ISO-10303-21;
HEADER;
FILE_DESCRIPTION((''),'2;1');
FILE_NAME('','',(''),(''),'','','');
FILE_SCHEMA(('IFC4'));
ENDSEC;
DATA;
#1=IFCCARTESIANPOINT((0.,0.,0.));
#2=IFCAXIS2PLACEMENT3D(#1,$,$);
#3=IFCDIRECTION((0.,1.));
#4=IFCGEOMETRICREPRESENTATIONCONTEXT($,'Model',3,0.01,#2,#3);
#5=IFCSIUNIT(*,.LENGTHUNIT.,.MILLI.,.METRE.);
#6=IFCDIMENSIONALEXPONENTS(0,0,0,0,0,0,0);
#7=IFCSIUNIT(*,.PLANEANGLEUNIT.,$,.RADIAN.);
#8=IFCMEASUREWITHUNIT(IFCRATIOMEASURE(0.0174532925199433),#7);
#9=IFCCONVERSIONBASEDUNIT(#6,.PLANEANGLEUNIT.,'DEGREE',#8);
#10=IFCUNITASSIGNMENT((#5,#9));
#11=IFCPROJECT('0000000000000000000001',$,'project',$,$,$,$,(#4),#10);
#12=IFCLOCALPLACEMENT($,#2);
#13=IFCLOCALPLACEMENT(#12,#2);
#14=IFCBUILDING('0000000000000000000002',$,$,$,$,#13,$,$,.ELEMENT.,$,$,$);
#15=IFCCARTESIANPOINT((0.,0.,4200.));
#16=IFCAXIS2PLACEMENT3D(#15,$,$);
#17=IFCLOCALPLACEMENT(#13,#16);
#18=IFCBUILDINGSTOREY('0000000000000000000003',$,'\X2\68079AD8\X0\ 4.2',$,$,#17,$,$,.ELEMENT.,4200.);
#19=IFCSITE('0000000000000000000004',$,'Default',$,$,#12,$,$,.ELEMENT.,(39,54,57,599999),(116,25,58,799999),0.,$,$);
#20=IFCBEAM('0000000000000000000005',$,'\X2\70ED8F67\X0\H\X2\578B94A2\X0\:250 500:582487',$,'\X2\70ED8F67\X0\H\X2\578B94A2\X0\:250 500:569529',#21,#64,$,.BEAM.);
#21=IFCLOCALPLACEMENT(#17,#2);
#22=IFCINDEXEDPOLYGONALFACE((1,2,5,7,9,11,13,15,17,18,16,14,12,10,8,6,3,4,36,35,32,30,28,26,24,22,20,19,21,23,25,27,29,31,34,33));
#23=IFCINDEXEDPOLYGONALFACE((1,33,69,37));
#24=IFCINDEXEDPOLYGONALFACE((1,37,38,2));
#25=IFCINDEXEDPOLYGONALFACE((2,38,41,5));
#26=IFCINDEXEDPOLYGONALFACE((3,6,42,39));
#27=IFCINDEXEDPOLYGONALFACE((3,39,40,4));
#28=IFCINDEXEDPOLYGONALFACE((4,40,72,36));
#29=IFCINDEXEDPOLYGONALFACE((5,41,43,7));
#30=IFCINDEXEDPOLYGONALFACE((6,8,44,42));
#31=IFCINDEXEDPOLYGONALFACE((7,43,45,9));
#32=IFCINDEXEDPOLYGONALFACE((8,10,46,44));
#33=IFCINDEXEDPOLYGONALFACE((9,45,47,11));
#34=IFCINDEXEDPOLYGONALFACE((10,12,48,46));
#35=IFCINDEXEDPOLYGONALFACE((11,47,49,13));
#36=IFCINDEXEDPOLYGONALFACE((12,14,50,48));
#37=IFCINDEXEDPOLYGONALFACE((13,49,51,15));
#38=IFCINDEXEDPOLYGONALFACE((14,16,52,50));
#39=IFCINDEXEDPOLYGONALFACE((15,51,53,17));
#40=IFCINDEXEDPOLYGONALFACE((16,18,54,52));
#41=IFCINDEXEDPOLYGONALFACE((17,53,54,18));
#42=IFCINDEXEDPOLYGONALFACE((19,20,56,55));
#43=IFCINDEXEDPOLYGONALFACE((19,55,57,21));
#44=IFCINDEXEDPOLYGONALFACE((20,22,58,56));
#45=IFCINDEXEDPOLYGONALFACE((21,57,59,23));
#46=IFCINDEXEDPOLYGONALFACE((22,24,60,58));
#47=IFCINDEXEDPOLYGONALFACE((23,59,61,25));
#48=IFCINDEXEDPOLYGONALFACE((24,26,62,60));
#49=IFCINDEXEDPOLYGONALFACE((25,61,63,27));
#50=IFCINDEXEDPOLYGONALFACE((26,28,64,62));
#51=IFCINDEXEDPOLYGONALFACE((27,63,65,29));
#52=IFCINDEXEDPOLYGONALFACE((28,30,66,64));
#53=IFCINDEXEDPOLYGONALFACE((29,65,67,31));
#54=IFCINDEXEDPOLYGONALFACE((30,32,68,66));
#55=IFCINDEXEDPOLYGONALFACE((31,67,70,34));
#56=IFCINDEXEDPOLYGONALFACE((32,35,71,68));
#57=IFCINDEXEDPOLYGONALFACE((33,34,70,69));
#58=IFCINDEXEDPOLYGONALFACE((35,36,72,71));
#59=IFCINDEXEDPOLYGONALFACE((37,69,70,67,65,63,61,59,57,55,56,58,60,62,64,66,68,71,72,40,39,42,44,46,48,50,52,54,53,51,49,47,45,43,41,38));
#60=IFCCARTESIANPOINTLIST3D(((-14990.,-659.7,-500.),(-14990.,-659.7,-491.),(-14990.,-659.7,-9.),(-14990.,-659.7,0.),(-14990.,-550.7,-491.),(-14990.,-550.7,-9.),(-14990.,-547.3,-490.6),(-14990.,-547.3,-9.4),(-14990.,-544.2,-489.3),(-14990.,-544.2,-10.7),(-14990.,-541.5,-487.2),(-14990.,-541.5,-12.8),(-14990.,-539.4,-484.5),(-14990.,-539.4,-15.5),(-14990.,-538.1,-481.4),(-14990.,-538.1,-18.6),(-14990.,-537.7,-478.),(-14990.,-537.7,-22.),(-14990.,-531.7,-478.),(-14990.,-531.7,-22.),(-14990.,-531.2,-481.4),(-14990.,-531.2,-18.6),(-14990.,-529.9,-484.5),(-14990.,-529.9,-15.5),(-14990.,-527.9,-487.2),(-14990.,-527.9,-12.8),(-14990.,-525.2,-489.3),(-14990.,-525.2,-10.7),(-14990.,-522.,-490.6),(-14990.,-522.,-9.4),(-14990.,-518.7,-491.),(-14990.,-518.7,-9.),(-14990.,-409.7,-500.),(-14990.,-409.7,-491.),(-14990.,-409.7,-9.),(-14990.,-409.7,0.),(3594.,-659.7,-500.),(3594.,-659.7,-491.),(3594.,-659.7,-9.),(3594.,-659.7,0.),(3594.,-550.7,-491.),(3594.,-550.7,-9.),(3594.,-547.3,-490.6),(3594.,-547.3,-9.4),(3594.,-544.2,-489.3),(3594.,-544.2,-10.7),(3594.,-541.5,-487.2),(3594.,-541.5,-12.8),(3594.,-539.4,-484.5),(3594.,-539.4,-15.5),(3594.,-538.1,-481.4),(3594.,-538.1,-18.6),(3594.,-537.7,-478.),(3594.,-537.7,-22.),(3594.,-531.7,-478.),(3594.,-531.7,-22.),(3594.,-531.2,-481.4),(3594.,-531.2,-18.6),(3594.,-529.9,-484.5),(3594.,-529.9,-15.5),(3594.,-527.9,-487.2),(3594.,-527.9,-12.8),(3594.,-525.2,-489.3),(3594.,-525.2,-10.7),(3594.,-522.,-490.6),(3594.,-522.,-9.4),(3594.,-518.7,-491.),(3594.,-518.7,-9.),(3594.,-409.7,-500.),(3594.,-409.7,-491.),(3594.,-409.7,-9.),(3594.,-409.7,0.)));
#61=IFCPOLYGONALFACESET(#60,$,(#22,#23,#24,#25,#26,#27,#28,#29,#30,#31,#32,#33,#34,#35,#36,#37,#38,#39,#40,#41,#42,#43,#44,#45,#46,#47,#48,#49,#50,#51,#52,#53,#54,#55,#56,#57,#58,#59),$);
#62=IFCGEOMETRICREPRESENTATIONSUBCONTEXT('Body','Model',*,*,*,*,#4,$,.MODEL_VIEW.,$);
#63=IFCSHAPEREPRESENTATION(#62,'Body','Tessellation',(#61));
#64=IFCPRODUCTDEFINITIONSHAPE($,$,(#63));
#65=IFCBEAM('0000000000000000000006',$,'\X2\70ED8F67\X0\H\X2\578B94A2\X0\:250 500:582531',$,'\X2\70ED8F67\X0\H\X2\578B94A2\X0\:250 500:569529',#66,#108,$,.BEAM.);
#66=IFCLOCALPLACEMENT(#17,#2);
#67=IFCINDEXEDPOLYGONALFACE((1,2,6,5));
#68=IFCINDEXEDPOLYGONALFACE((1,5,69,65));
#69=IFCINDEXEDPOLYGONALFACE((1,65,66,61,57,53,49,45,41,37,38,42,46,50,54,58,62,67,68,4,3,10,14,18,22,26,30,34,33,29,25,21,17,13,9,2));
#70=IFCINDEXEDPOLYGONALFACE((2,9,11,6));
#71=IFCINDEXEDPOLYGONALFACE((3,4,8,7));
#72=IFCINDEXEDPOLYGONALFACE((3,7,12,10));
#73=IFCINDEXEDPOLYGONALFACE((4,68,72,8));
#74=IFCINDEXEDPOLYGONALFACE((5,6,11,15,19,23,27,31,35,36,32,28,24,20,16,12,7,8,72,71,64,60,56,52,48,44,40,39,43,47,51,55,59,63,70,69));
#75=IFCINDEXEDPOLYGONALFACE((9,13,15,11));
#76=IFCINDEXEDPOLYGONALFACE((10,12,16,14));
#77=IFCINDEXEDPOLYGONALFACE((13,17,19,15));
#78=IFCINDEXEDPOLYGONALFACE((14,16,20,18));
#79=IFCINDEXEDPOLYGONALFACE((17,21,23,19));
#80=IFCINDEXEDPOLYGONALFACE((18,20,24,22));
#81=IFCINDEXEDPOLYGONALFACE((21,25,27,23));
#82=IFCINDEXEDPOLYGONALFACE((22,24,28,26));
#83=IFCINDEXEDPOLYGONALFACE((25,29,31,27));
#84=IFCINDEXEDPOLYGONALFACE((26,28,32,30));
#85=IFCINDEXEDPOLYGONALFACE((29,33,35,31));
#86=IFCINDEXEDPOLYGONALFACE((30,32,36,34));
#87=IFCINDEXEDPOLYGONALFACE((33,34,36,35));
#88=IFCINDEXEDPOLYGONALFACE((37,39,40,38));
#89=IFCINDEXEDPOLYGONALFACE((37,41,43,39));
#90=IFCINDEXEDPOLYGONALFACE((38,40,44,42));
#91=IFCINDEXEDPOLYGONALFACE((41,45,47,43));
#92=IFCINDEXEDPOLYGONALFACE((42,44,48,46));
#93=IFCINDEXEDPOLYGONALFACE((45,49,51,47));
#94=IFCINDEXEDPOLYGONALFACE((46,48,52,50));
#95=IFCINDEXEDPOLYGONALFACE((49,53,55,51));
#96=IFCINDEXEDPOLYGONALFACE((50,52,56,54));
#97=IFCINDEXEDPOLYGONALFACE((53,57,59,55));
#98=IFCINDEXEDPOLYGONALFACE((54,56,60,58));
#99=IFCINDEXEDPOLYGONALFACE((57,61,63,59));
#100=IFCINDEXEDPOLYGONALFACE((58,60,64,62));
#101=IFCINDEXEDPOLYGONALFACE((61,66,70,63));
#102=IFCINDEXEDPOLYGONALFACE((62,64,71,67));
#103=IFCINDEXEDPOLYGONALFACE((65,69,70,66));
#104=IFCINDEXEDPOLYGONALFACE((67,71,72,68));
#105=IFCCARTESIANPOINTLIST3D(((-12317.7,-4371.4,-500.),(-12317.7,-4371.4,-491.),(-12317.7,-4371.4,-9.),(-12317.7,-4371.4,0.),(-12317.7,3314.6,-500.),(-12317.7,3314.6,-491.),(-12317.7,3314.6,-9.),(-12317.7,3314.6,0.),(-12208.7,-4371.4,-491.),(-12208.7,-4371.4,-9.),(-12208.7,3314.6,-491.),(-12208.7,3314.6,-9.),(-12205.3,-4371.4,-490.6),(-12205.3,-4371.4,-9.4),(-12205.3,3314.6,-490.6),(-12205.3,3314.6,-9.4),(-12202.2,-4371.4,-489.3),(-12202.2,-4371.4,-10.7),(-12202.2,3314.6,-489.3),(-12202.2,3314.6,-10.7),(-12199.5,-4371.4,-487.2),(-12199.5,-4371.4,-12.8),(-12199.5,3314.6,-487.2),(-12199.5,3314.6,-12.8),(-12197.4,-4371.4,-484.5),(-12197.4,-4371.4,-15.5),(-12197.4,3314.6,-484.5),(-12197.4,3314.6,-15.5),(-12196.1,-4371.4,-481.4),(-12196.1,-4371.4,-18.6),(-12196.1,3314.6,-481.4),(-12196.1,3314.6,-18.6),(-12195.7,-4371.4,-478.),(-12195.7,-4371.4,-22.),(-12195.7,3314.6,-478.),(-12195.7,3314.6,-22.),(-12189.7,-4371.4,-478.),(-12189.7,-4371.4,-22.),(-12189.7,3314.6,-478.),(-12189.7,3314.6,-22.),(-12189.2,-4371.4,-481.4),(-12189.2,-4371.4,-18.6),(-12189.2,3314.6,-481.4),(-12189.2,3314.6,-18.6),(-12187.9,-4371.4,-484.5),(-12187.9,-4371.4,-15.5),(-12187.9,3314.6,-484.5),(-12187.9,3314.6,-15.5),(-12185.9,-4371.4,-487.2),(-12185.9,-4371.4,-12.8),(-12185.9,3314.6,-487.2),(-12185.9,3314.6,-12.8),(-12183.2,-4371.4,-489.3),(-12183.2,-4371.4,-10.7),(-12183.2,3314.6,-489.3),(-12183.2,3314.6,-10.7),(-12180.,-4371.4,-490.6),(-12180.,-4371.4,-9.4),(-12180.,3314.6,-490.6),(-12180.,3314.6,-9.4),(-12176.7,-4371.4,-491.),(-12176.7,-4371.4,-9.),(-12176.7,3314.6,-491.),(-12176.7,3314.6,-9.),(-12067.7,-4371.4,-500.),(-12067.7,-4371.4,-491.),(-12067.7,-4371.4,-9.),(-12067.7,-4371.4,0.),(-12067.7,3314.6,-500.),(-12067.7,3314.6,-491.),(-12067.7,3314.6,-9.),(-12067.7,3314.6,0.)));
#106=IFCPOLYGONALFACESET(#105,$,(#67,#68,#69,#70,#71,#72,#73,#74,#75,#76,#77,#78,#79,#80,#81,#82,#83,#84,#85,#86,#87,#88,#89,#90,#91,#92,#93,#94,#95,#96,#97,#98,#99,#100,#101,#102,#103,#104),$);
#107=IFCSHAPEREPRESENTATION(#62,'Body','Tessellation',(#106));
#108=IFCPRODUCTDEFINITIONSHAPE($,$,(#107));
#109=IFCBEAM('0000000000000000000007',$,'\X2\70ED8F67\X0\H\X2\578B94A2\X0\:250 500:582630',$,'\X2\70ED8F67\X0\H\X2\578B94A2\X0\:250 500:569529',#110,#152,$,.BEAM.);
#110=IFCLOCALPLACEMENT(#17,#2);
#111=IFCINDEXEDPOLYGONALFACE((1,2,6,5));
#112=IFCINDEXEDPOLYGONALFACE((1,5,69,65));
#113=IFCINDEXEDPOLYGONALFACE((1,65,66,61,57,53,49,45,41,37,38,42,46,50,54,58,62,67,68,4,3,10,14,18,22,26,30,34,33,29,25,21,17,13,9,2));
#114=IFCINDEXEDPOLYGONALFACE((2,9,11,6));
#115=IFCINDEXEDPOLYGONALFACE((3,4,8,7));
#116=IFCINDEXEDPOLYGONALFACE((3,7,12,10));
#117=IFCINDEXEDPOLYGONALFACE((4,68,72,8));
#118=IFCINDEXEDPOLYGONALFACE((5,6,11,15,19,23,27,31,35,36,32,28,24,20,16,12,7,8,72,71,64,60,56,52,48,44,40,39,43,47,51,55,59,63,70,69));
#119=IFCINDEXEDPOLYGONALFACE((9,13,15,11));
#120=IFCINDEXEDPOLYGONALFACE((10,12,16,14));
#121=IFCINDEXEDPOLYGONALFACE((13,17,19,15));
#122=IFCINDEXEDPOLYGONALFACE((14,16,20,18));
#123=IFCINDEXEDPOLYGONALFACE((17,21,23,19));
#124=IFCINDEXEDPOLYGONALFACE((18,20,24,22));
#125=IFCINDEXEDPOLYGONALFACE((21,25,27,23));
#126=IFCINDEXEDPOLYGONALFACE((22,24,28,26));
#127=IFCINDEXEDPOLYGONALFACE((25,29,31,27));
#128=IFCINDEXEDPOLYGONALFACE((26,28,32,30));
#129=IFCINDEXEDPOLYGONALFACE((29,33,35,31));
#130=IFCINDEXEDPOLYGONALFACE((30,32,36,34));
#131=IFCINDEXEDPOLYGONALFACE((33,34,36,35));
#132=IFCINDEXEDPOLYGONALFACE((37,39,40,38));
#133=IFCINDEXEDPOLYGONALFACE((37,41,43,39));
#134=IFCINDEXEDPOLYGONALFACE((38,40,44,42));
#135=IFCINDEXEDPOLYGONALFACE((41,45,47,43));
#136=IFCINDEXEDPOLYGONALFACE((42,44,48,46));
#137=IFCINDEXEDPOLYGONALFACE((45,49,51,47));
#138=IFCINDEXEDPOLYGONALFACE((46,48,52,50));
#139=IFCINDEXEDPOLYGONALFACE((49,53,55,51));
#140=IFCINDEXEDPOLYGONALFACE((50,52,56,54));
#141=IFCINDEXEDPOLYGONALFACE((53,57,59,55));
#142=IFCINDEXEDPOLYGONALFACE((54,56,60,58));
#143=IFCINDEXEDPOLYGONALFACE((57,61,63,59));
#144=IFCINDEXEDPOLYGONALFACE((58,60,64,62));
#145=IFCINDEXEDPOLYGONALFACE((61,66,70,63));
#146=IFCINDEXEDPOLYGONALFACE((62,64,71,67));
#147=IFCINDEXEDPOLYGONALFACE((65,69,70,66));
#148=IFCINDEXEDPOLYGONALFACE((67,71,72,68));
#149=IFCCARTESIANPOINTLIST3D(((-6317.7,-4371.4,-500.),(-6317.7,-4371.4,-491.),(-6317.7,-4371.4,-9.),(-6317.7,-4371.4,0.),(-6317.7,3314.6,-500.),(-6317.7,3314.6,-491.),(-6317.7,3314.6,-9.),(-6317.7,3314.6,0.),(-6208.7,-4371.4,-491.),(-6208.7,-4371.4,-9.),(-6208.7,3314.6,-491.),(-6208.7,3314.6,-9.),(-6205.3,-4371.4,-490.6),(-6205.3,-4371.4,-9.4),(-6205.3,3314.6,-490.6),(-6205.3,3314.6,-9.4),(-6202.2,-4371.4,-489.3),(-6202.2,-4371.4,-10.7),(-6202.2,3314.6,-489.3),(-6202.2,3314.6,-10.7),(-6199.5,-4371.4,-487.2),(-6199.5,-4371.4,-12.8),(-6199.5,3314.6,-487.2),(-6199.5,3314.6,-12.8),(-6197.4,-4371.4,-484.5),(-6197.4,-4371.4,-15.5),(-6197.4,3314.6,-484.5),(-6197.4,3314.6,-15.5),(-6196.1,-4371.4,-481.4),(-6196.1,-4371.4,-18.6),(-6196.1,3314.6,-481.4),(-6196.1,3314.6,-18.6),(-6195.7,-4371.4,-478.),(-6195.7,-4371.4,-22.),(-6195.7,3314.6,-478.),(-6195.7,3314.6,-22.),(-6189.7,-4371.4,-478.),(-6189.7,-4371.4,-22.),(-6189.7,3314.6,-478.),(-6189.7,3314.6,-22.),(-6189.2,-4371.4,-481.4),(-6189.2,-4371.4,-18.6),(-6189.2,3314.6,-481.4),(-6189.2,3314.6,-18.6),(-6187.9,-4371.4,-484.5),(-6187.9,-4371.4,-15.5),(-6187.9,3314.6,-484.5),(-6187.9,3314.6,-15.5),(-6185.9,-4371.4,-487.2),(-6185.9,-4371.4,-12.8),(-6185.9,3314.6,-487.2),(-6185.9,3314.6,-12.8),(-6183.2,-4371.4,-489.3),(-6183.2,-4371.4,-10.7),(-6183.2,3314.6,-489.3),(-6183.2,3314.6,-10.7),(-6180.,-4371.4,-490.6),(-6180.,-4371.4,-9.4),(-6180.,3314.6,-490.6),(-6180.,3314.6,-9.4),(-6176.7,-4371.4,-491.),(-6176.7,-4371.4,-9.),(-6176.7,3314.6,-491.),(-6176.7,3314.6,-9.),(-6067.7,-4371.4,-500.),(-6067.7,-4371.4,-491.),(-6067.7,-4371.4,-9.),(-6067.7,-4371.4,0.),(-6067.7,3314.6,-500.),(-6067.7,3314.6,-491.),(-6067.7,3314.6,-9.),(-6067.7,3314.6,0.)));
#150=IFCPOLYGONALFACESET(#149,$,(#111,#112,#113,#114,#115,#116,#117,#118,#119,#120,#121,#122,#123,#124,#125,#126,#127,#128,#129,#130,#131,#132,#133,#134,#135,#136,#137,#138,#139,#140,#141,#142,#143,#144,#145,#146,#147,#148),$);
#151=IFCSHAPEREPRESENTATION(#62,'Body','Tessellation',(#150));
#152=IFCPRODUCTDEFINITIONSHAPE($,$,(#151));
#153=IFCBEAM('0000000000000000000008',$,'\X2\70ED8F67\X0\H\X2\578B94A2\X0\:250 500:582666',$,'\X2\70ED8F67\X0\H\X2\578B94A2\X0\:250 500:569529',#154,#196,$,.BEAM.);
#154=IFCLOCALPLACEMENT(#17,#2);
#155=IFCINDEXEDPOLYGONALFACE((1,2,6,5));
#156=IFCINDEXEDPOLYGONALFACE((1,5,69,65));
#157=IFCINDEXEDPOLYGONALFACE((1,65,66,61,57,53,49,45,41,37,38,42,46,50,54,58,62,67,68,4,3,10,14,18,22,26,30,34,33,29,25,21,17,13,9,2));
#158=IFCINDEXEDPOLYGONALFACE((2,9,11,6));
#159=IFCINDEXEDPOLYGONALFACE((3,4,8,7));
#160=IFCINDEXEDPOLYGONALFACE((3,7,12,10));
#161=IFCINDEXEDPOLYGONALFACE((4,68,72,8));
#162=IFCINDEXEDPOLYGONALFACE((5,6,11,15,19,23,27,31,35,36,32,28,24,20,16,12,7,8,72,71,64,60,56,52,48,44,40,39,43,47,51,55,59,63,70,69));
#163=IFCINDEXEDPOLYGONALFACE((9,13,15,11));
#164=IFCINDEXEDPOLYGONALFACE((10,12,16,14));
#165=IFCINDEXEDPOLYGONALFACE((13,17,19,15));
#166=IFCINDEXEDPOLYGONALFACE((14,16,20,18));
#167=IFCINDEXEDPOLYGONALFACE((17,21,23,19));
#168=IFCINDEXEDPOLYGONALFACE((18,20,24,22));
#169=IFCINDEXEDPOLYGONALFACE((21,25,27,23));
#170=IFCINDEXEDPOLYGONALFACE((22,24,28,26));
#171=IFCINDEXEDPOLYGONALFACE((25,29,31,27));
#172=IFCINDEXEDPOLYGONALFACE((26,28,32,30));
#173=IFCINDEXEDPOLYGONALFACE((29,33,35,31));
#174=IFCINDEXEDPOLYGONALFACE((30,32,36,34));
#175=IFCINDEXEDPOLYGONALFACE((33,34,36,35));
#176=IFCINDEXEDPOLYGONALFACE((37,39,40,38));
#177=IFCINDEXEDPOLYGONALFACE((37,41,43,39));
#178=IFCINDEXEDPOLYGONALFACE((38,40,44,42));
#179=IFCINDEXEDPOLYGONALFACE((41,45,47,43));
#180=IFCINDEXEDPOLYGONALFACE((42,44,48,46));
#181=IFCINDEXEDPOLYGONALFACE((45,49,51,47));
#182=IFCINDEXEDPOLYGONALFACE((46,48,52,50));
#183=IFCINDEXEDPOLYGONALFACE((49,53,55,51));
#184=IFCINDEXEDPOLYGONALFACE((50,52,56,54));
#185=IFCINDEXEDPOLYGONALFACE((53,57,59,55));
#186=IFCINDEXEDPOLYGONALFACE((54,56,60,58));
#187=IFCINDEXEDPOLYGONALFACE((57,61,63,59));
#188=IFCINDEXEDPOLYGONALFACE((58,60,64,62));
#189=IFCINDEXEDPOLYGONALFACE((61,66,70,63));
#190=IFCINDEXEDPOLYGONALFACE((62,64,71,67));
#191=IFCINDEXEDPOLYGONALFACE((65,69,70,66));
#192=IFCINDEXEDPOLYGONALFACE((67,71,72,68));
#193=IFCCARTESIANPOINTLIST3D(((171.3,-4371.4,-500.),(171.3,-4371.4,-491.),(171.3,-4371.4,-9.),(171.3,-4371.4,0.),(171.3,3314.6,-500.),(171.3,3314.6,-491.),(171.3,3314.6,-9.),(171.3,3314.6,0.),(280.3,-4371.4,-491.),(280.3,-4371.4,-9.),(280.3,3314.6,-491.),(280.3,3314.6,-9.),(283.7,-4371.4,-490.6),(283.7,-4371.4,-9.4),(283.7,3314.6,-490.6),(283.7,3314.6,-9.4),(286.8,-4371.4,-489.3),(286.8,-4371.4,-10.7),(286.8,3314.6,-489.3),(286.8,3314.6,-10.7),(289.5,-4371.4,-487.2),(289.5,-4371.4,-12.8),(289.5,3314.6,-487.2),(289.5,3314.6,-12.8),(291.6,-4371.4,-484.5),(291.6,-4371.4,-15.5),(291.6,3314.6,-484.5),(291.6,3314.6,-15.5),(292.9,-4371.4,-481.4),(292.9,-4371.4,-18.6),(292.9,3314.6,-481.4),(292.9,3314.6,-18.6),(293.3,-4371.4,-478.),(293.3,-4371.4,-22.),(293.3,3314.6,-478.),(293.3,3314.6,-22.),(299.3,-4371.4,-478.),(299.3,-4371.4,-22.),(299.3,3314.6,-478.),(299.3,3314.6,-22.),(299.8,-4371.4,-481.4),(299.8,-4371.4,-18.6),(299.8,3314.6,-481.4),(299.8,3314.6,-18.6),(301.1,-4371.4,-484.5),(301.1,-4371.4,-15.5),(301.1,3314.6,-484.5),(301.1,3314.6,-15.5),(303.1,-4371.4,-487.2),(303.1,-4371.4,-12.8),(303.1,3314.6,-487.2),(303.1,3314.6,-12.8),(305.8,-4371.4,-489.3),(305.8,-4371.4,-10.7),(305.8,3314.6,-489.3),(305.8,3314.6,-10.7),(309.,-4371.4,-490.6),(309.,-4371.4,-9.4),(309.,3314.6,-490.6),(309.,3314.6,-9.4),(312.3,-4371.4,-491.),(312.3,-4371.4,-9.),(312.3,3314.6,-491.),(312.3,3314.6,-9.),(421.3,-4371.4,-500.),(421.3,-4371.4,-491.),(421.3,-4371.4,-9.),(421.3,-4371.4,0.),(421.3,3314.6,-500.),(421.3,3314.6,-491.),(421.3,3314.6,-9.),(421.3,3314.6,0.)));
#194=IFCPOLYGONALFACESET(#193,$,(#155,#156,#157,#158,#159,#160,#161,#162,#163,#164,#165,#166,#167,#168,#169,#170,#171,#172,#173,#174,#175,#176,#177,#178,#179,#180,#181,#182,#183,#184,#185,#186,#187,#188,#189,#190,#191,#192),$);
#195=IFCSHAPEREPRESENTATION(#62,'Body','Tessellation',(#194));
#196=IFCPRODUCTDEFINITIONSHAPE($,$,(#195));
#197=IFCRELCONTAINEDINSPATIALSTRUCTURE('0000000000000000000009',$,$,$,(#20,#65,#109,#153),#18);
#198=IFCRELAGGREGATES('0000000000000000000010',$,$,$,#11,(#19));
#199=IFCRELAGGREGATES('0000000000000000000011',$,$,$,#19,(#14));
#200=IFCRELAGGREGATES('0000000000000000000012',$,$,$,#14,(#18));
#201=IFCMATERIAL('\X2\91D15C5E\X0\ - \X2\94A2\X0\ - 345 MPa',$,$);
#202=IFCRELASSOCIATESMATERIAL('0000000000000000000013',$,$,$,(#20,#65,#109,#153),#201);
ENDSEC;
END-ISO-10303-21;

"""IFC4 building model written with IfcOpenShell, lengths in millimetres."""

from ifc_helpers import new_model, entity, si_unit, converted_unit, direction, frame, frame_2d, origin, place, context, subcontext, project, spatial, i_section, extrude, material, element, save


model = new_model("IFC4")

# Units and contexts
model_context = context("Model", 3, precision=0.01, world=origin(), true_north=direction((0.0, 1.0)))
body_context = subcontext(model_context, "Body", "Model", "MODEL_VIEW")
ifc_project = project(units=[si_unit("LENGTHUNIT", "METRE", prefix="MILLI"), converted_unit("PLANEANGLEUNIT", "DEGREE", entity("IfcRatioMeasure", 0.0174532925199433), si_unit("PLANEANGLEUNIT", "RADIAN"), dimensions=[0, 0, 0, 0, 0, 0, 0])], contexts=[model_context])

# Site, building, storey
site_placement = place(None, origin())
site = spatial("IfcSite", under=ifc_project, at=site_placement, Name="Default", CompositionType="ELEMENT", RefLatitude=(39, 54, 57, 599999), RefLongitude=(116, 25, 58, 799999), RefElevation=0.0)
building_placement = place(site_placement, origin())
building = spatial("IfcBuilding", under=site, at=building_placement, CompositionType="ELEMENT")
storey_placement = place(building_placement, frame((0.0, 0.0, 4200.0)))
storey = spatial("IfcBuildingStorey", under=building, at=storey_placement, Name="标高 4.2", CompositionType="ELEMENT", Elevation=4200.0)

# Beams
ifc_material_1 = material(Name="金属 - 钢 - 345 MPa")
beam_1_placement = place(storey_placement, frame((-14990.3, -534.7, 0.0)))
element("IfcBeam", 1, at=beam_1_placement, inside=storey, material=ifc_material_1, Name="热轧H型钢:250 500:582487", ObjectType="热轧H型钢:250 500:569529", PredefinedType="BEAM", context=body_context, shape_type="SweptSolid", body=[
    extrude(i_section(OverallWidth=250.0, OverallDepth=500.0, WebThickness=6.0, FlangeThickness=9.0, FilletRadius=13.0, at=frame_2d((0.0, 0.0), x_axis=(0.0, 1.0))), frame((0.3, 0.0, -250.0), z_axis=(1.0, 0.0, 0.0), x_axis=(0.0, 0.0, -1.0)), (0.0, 0.0, 1.0), 18584.0),
])
beam_2_placement = place(storey_placement, frame((-12192.7, -4534.7, 0.0), z_axis=(0.0, 0.0, 1.0), x_axis=(0.0, 1.0, 0.0)))
element("IfcBeam", 2, at=beam_2_placement, inside=storey, material=ifc_material_1, Name="热轧H型钢:250 500:582531", ObjectType="热轧H型钢:250 500:569529", PredefinedType="BEAM", context=body_context, shape_type="SweptSolid", body=[
    extrude(i_section(OverallWidth=250.0, OverallDepth=500.0, WebThickness=6.0, FlangeThickness=9.0, FilletRadius=13.0, at=frame_2d((0.0, 0.0), x_axis=(0.0, 1.0))), frame((163.3, 0.0, -250.0), z_axis=(1.0, 0.0, 0.0), x_axis=(0.0, 0.0, -1.0)), (0.0, 0.0, 1.0), 7686.0),
])
beam_3_placement = place(storey_placement, frame((-6192.7, 3314.9, 0.0), z_axis=(0.0, 0.0, 1.0), x_axis=(0.0, -1.0, 0.0)))
element("IfcBeam", 3, at=beam_3_placement, inside=storey, material=ifc_material_1, Name="热轧H型钢:250 500:582630", ObjectType="热轧H型钢:250 500:569529", PredefinedType="BEAM", context=body_context, shape_type="SweptSolid", body=[
    extrude(i_section(OverallWidth=250.0, OverallDepth=500.0, WebThickness=6.0, FlangeThickness=9.0, FilletRadius=13.0, at=frame_2d((0.0, 0.0), x_axis=(0.0, 1.0))), frame((0.3, 0.0, -250.0), z_axis=(1.0, 0.0, 0.0), x_axis=(0.0, 0.0, -1.0)), (0.0, 0.0, 1.0), 7686.0),
])
beam_4_placement = place(storey_placement, frame((296.3, -4534.7, 0.0), z_axis=(0.0, 0.0, 1.0), x_axis=(0.0, 1.0, 0.0)))
element("IfcBeam", 4, at=beam_4_placement, inside=storey, material=ifc_material_1, Name="热轧H型钢:250 500:582666", ObjectType="热轧H型钢:250 500:569529", PredefinedType="BEAM", context=body_context, shape_type="SweptSolid", body=[
    extrude(i_section(OverallWidth=250.0, OverallDepth=500.0, WebThickness=6.0, FlangeThickness=9.0, FilletRadius=13.0, at=frame_2d((0.0, 0.0), x_axis=(0.0, 1.0))), frame((163.3, 0.0, -250.0), z_axis=(1.0, 0.0, 0.0), x_axis=(0.0, 0.0, -1.0)), (0.0, 0.0, 1.0), 7686.0),
])

save(model, "model.ifc")
